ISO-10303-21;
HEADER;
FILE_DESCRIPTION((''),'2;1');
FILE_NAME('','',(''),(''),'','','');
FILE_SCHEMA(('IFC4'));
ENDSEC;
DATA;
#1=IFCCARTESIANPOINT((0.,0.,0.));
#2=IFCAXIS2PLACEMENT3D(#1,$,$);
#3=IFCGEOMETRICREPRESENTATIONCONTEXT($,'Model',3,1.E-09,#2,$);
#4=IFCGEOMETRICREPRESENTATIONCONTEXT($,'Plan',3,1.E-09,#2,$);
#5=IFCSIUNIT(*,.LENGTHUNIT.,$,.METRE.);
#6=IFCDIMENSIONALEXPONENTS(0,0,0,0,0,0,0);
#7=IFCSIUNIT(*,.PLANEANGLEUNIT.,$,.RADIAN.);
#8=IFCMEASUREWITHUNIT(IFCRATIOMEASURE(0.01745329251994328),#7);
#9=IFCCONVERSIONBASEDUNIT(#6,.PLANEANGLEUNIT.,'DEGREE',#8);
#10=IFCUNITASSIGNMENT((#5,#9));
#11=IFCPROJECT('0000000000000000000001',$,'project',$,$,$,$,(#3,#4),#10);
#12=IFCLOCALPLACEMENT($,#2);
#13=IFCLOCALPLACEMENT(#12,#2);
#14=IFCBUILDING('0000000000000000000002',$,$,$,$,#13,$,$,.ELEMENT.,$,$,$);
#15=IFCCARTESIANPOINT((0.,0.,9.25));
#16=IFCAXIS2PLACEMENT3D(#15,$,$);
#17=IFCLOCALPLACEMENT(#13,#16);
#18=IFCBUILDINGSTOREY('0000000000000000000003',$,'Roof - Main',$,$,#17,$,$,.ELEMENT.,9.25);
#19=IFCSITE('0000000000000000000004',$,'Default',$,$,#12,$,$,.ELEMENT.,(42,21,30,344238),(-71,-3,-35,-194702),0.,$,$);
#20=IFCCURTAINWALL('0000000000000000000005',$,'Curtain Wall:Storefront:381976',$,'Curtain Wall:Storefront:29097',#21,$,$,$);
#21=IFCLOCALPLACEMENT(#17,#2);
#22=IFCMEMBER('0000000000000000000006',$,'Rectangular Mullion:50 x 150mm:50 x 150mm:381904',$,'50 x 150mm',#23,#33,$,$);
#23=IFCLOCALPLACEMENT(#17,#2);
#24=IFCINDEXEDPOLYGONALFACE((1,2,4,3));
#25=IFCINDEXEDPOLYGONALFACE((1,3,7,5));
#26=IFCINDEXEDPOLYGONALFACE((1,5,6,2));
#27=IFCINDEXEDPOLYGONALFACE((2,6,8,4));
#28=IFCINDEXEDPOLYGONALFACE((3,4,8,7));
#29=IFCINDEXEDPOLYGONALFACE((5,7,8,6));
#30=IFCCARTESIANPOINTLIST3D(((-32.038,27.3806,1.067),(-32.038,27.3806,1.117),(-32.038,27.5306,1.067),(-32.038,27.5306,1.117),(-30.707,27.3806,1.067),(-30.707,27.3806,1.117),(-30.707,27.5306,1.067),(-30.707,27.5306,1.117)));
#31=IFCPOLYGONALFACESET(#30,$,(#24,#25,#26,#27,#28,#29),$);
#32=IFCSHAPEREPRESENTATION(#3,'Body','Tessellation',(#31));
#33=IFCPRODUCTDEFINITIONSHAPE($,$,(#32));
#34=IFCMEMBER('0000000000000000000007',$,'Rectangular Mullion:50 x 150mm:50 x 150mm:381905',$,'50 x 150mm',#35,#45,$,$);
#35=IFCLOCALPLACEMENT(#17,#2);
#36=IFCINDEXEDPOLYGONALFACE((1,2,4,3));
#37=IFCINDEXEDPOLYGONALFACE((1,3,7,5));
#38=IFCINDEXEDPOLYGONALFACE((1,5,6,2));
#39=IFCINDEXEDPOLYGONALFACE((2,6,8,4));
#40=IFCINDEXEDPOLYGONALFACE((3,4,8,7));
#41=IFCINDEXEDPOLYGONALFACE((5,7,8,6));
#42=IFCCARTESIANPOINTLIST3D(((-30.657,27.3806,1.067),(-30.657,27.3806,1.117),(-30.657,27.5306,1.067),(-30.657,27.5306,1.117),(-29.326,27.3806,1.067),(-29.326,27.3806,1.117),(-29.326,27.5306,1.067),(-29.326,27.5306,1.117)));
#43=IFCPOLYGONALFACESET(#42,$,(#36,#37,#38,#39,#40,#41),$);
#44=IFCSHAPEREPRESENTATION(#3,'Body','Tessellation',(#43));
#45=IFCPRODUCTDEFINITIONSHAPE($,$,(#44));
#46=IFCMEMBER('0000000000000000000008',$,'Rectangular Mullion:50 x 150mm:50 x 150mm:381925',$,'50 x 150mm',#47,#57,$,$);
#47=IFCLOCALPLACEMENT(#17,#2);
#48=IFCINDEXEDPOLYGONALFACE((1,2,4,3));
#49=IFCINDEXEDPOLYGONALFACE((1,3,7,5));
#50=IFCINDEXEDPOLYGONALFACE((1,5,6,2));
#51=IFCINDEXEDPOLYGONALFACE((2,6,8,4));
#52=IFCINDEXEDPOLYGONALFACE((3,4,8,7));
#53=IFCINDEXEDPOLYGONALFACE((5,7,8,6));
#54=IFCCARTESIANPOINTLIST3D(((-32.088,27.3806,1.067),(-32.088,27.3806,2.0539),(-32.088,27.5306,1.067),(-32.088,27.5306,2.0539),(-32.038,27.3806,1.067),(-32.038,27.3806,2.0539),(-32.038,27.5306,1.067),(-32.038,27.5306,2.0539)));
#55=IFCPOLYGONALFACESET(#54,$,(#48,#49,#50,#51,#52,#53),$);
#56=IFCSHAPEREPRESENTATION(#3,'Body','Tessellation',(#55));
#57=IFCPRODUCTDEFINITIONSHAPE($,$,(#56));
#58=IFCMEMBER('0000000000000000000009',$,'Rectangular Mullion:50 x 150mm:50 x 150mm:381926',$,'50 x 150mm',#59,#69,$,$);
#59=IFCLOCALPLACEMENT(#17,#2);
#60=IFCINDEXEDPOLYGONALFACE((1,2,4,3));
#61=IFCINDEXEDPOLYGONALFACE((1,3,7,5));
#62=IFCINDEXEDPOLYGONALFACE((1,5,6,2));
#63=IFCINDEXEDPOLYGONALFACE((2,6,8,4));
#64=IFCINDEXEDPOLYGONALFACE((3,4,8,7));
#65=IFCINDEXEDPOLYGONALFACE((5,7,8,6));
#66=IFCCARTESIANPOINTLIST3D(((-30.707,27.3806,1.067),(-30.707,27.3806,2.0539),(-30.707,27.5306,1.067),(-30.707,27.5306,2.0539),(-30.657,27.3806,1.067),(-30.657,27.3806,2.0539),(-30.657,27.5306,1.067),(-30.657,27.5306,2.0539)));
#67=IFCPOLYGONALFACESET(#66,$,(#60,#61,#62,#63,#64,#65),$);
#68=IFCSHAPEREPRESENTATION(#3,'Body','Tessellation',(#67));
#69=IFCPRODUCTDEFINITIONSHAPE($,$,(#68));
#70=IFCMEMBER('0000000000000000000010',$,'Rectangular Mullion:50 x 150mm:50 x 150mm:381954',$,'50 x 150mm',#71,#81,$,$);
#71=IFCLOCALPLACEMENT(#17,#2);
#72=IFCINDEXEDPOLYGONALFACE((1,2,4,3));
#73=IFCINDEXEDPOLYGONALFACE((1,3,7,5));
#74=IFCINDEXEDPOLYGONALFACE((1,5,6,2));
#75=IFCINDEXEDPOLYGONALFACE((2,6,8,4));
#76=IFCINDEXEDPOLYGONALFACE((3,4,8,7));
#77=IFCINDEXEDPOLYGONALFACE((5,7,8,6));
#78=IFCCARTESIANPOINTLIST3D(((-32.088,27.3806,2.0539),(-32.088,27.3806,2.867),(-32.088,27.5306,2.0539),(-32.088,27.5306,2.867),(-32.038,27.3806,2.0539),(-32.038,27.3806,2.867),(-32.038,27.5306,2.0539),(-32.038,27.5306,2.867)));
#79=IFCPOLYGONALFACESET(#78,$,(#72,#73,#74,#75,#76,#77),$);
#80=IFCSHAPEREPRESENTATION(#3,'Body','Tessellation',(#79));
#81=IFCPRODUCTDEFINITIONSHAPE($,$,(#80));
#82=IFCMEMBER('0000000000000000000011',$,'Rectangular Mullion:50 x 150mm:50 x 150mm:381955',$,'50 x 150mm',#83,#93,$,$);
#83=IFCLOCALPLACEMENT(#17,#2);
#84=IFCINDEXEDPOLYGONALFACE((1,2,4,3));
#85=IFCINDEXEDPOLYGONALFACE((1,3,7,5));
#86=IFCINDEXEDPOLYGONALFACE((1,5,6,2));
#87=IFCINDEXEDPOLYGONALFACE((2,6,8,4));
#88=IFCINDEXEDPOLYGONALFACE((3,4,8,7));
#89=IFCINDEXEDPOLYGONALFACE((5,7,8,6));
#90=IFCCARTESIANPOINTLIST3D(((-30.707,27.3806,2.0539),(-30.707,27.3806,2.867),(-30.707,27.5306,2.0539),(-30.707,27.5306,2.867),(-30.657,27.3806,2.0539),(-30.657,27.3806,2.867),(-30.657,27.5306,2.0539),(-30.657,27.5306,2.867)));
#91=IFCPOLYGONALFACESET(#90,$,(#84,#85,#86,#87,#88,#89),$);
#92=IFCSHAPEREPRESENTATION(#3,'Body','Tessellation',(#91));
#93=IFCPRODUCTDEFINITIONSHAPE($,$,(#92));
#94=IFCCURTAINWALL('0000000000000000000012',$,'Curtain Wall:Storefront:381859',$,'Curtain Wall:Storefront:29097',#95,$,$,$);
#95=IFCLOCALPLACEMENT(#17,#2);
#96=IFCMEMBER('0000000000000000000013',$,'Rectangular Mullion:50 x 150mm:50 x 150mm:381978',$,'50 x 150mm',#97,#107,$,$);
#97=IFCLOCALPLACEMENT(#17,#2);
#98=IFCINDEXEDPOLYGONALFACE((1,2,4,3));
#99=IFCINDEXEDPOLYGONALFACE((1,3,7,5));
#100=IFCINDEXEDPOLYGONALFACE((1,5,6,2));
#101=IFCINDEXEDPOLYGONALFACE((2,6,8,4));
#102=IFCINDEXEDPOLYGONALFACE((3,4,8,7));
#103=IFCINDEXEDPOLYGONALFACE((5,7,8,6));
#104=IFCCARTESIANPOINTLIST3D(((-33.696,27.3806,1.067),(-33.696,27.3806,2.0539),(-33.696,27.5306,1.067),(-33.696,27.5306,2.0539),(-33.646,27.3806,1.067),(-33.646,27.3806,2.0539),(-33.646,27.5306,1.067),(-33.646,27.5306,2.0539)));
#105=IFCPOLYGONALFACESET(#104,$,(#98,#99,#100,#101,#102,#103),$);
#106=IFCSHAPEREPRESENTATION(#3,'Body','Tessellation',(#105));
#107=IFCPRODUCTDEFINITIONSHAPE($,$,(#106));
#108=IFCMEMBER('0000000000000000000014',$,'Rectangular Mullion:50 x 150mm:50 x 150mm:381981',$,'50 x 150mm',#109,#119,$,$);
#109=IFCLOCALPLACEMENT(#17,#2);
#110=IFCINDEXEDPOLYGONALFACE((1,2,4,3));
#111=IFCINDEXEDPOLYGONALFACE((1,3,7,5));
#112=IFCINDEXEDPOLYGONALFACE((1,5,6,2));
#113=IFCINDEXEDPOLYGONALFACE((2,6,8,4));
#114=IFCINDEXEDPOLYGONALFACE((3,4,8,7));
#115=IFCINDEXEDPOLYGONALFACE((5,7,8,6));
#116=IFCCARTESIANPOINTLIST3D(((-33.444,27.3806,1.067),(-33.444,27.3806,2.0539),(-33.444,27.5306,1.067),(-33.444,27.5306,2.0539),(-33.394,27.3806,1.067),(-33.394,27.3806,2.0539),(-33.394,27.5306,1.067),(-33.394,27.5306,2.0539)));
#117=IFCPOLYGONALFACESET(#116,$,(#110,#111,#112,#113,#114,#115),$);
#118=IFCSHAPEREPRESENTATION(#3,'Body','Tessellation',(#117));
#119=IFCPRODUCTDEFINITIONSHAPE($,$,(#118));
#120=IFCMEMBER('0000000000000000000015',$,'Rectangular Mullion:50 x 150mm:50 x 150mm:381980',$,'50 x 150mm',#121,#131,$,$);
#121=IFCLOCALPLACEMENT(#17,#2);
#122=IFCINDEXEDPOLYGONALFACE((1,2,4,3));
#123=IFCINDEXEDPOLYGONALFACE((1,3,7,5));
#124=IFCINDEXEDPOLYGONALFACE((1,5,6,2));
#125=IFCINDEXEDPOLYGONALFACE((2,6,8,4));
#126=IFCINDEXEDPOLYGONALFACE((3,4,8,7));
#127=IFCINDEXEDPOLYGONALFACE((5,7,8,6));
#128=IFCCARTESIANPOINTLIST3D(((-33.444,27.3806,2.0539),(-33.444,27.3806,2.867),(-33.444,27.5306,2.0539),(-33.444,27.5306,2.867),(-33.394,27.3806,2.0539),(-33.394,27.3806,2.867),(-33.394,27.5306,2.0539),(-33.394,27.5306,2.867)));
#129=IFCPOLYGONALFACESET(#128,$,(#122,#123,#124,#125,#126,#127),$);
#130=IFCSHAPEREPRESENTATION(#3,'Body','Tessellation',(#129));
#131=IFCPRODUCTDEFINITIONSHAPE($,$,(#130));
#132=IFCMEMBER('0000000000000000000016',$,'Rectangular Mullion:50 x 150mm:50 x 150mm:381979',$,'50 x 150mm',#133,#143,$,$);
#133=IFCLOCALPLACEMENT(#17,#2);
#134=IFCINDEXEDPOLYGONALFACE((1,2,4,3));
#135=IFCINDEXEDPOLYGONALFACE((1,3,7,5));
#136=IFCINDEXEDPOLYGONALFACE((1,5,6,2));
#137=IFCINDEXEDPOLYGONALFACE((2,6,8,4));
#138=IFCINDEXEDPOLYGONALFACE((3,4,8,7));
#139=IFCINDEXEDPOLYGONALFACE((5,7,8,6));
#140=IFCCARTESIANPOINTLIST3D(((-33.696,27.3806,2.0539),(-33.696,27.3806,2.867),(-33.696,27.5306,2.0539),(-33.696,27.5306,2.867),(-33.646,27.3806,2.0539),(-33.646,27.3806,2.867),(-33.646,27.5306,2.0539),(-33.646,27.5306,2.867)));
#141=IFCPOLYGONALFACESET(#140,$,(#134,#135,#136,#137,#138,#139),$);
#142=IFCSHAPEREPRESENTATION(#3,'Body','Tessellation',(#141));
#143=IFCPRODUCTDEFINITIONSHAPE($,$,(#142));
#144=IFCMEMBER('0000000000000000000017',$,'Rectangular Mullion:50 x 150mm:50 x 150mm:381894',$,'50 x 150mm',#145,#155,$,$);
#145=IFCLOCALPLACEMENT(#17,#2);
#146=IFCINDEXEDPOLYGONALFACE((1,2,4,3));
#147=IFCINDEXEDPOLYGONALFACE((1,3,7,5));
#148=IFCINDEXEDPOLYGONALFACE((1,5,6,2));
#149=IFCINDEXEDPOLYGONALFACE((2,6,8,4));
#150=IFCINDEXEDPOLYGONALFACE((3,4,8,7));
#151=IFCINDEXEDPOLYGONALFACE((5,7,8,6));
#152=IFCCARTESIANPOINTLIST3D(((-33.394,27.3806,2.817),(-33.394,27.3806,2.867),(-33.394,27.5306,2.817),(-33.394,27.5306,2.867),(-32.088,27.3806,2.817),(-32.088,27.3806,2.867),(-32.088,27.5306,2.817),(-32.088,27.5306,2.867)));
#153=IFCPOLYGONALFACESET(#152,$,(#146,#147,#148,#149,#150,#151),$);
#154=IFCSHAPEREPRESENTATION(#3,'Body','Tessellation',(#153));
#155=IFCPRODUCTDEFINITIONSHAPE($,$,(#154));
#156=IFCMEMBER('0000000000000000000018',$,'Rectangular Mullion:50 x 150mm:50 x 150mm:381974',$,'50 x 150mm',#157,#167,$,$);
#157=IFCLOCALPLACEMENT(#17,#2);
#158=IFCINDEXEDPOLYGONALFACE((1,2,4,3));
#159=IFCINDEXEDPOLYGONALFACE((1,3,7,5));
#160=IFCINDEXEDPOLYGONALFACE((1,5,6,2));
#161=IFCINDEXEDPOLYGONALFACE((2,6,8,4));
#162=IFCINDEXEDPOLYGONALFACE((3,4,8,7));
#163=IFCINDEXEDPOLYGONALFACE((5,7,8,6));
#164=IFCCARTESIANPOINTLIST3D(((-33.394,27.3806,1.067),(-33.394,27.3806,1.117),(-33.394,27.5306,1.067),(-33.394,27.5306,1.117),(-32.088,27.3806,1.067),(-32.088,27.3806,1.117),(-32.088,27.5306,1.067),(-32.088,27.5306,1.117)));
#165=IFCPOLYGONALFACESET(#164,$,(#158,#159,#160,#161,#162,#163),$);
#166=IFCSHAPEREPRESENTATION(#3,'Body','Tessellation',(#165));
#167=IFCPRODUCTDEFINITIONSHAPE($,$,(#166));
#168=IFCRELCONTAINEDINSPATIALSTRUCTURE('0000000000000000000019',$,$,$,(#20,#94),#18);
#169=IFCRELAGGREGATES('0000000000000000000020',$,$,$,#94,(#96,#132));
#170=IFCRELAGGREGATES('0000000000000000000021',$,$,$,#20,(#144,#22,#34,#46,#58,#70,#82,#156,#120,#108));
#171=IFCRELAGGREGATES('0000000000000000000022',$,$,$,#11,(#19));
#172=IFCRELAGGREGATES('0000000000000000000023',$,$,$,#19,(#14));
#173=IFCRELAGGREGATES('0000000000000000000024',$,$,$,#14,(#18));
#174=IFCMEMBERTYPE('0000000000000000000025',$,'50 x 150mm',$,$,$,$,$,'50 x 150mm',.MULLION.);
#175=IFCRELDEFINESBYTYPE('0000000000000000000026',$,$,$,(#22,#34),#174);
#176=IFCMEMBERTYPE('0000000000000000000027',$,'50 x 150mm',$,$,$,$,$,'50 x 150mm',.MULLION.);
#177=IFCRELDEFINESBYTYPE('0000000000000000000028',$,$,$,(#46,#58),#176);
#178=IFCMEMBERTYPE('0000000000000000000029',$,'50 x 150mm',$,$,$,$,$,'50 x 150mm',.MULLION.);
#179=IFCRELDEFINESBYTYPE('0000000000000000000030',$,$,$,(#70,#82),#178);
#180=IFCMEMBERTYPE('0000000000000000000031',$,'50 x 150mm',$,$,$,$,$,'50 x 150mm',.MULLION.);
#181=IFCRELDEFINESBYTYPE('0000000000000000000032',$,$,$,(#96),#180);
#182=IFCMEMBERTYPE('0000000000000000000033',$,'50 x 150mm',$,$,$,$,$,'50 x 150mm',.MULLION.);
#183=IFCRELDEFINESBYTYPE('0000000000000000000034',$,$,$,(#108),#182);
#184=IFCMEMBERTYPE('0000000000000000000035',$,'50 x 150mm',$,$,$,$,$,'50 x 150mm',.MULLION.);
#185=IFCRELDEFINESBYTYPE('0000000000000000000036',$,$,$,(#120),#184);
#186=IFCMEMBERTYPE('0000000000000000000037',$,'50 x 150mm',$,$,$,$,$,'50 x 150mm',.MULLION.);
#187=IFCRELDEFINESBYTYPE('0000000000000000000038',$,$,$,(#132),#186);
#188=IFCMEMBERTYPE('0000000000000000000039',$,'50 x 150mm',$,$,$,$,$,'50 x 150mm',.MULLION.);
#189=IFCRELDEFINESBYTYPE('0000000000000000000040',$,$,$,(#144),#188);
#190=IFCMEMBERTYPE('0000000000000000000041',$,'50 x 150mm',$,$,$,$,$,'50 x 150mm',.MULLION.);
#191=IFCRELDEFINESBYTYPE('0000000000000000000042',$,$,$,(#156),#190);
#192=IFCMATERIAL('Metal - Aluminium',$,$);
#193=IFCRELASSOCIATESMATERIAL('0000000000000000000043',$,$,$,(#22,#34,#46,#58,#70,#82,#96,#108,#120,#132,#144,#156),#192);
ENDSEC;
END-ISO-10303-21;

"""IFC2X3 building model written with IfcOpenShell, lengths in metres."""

from ifc_helpers import new_model, entity, si_unit, converted_unit, frame, origin, origin_2d_with_axis, place, context, project, spatial, rectangle, extrude, source, transform, mapped, material, type_object, type_shapes, element, aggregate, save


model = new_model("IFC2X3")

# Units and contexts
model_context = context("Model", 3, precision=1e-09, world=origin())
plan_context = context("Plan", 3, precision=1e-09, world=origin())
ifc_project = project(units=[si_unit("LENGTHUNIT", "METRE"), converted_unit("PLANEANGLEUNIT", "DEGREE", entity("IfcRatioMeasure", 0.01745329251994328), si_unit("PLANEANGLEUNIT", "RADIAN"), dimensions=[0, 0, 0, 0, 0, 0, 0])], contexts=[model_context, plan_context])

# Site, building, storey
site_placement = place(None, origin())
site = spatial("IfcSite", under=ifc_project, at=site_placement, Name="Default", CompositionType="ELEMENT", RefLatitude=(42, 21, 30, 344238), RefLongitude=(-71, -3, -35, -194702), RefElevation=0.0)
building_placement = place(site_placement, origin())
building = spatial("IfcBuilding", under=site, at=building_placement, CompositionType="ELEMENT")
storey_placement = place(building_placement, frame((0.0, 0.0, 9.25)))
storey = spatial("IfcBuildingStorey", under=building, at=storey_placement, Name="Roof - Main", CompositionType="ELEMENT", Elevation=9.25)

# Curtain wall, members
curtain_wall_1_placement = place(storey_placement, origin())
curtain_wall_1 = element("IfcCurtainWall", 1, at=curtain_wall_1_placement, inside=storey, Name="Curtain Wall:Storefront:381976", ObjectType="Curtain Wall:Storefront:29097")
ifc_material_1 = material(Name="Metal - Aluminium")
member_type_1 = type_object("IfcMemberType", Name="50 x 150mm", ElementType="50 x 150mm", PredefinedType="MULLION")
shared_shape_1 = source(origin(), model_context, "Body", "SweptSolid", [
    extrude(rectangle(XDim=0.05, YDim=0.15, at=origin_2d_with_axis()), frame((-0.025, 0.0, -1.331), z_axis=(0.0, 0.0, 1.0), x_axis=(-1.0, 0.0, 0.0)), (0.0, 0.0, 1.0), 1.331),
])
type_shapes(member_type_1, [shared_shape_1])
member_1_placement = place(storey_placement, frame((-32.038, 27.4556, 1.067), z_axis=(-1.0, 0.0, 0.0), x_axis=(0.0, 0.0, -1.0)))
member_1 = element("IfcMember", 2, at=member_1_placement, type_object=member_type_1, material=ifc_material_1, Name="Rectangular Mullion:50 x 150mm:50 x 150mm:381904", ObjectType="50 x 150mm", context=model_context, shape_type="MappedRepresentation", body=[
    mapped(shared_shape_1, transform((0.0, 0.0, 0.0), scale=1.0)),
])
member_2_placement = place(storey_placement, frame((-30.657, 27.4556, 1.067), z_axis=(-1.0, 0.0, 0.0), x_axis=(0.0, 0.0, -1.0)))
member_2 = element("IfcMember", 3, at=member_2_placement, type_object=member_type_1, material=ifc_material_1, Name="Rectangular Mullion:50 x 150mm:50 x 150mm:381905", ObjectType="50 x 150mm", context=model_context, shape_type="MappedRepresentation", body=[
    mapped(shared_shape_1, transform((0.0, 0.0, 0.0), scale=1.0)),
])
member_type_2 = type_object("IfcMemberType", Name="50 x 150mm", ElementType="50 x 150mm", PredefinedType="MULLION")
shared_shape_2 = source(origin(), model_context, "Body", "SweptSolid", [
    extrude(rectangle(XDim=0.05, YDim=0.15, at=origin_2d_with_axis()), frame((0.0, 0.0, -0.9869), z_axis=(0.0, 0.0, 1.0), x_axis=(-1.0, 0.0, 0.0)), (0.0, 0.0, 1.0), 0.9869),
])
type_shapes(member_type_2, [shared_shape_2])
member_3_placement = place(storey_placement, frame((-32.063, 27.4556, 1.067), z_axis=(0.0, 0.0, -1.0), x_axis=(1.0, 0.0, 0.0)))
member_3 = element("IfcMember", 4, at=member_3_placement, type_object=member_type_2, material=ifc_material_1, Name="Rectangular Mullion:50 x 150mm:50 x 150mm:381925", ObjectType="50 x 150mm", context=model_context, shape_type="MappedRepresentation", body=[
    mapped(shared_shape_2, transform((0.0, 0.0, 0.0), scale=1.0)),
])
member_4_placement = place(storey_placement, frame((-30.682, 27.4556, 1.067), z_axis=(0.0, 0.0, -1.0), x_axis=(1.0, 0.0, 0.0)))
member_4 = element("IfcMember", 5, at=member_4_placement, type_object=member_type_2, material=ifc_material_1, Name="Rectangular Mullion:50 x 150mm:50 x 150mm:381926", ObjectType="50 x 150mm", context=model_context, shape_type="MappedRepresentation", body=[
    mapped(shared_shape_2, transform((0.0, 0.0, 0.0), scale=1.0)),
])
member_type_3 = type_object("IfcMemberType", Name="50 x 150mm", ElementType="50 x 150mm", PredefinedType="MULLION")
shared_shape_3 = source(origin(), model_context, "Body", "SweptSolid", [
    extrude(rectangle(XDim=0.05, YDim=0.15, at=origin_2d_with_axis()), frame((0.0, 0.0, -0.8131), z_axis=(0.0, 0.0, 1.0), x_axis=(-1.0, 0.0, 0.0)), (0.0, 0.0, 1.0), 0.8131),
])
type_shapes(member_type_3, [shared_shape_3])
member_5_placement = place(storey_placement, frame((-32.063, 27.4556, 2.0539), z_axis=(0.0, 0.0, -1.0), x_axis=(1.0, 0.0, 0.0)))
member_5 = element("IfcMember", 6, at=member_5_placement, type_object=member_type_3, material=ifc_material_1, Name="Rectangular Mullion:50 x 150mm:50 x 150mm:381954", ObjectType="50 x 150mm", context=model_context, shape_type="MappedRepresentation", body=[
    mapped(shared_shape_3, transform((0.0, 0.0, 0.0), scale=1.0)),
])
member_6_placement = place(storey_placement, frame((-30.682, 27.4556, 2.0539), z_axis=(0.0, 0.0, -1.0), x_axis=(1.0, 0.0, 0.0)))
member_6 = element("IfcMember", 7, at=member_6_placement, type_object=member_type_3, material=ifc_material_1, Name="Rectangular Mullion:50 x 150mm:50 x 150mm:381955", ObjectType="50 x 150mm", context=model_context, shape_type="MappedRepresentation", body=[
    mapped(shared_shape_3, transform((0.0, 0.0, 0.0), scale=1.0)),
])

# Curtain wall, member
curtain_wall_2_placement = place(storey_placement, origin())
curtain_wall_2 = element("IfcCurtainWall", 8, at=curtain_wall_2_placement, inside=storey, Name="Curtain Wall:Storefront:381859", ObjectType="Curtain Wall:Storefront:29097")
member_type_4 = type_object("IfcMemberType", Name="50 x 150mm", ElementType="50 x 150mm", PredefinedType="MULLION")
shared_shape_4 = source(origin(), model_context, "Body", "SweptSolid", [
    extrude(rectangle(XDim=0.05, YDim=0.15, at=origin_2d_with_axis()), frame((-0.025, 0.0, -0.9869), z_axis=(0.0, 0.0, 1.0), x_axis=(-1.0, 0.0, 0.0)), (0.0, 0.0, 1.0), 0.9869),
])
type_shapes(member_type_4, [shared_shape_4])
member_7_placement = place(storey_placement, frame((-33.646, 27.4556, 1.067), z_axis=(0.0, 0.0, -1.0), x_axis=(1.0, 0.0, 0.0)))
member_7 = element("IfcMember", 9, at=member_7_placement, type_object=member_type_4, material=ifc_material_1, Name="Rectangular Mullion:50 x 150mm:50 x 150mm:381978", ObjectType="50 x 150mm", context=model_context, shape_type="MappedRepresentation", body=[
    mapped(shared_shape_4, transform((0.0, 0.0, 0.0), scale=1.0)),
])

# Members
member_type_5 = type_object("IfcMemberType", Name="50 x 150mm", ElementType="50 x 150mm", PredefinedType="MULLION")
shared_shape_5 = source(origin(), model_context, "Body", "SweptSolid", [
    extrude(rectangle(XDim=0.05, YDim=0.15, at=origin_2d_with_axis()), frame((-0.025, 0.0, -0.9869), z_axis=(0.0, 0.0, 1.0), x_axis=(-1.0, 0.0, 0.0)), (0.0, 0.0, 1.0), 0.9869),
])
type_shapes(member_type_5, [shared_shape_5])
member_8_placement = place(storey_placement, frame((-33.444, 27.4556, 2.0539), z_axis=(0.0, 0.0, 1.0), x_axis=(-1.0, 0.0, 0.0)))
member_8 = element("IfcMember", 10, at=member_8_placement, type_object=member_type_5, material=ifc_material_1, Name="Rectangular Mullion:50 x 150mm:50 x 150mm:381981", ObjectType="50 x 150mm", context=model_context, shape_type="MappedRepresentation", body=[
    mapped(shared_shape_5, transform((0.0, 0.0, 0.0), scale=1.0)),
])
member_type_6 = type_object("IfcMemberType", Name="50 x 150mm", ElementType="50 x 150mm", PredefinedType="MULLION")
shared_shape_6 = source(origin(), model_context, "Body", "SweptSolid", [
    extrude(rectangle(XDim=0.05, YDim=0.15, at=origin_2d_with_axis()), frame((-0.025, 0.0, -0.8131), z_axis=(0.0, 0.0, 1.0), x_axis=(-1.0, 0.0, 0.0)), (0.0, 0.0, 1.0), 0.8131),
])
type_shapes(member_type_6, [shared_shape_6])
member_9_placement = place(storey_placement, frame((-33.444, 27.4556, 2.867), z_axis=(0.0, 0.0, 1.0), x_axis=(-1.0, 0.0, 0.0)))
member_9 = element("IfcMember", 11, at=member_9_placement, type_object=member_type_6, material=ifc_material_1, Name="Rectangular Mullion:50 x 150mm:50 x 150mm:381980", ObjectType="50 x 150mm", context=model_context, shape_type="MappedRepresentation", body=[
    mapped(shared_shape_6, transform((0.0, 0.0, 0.0), scale=1.0)),
])
member_type_7 = type_object("IfcMemberType", Name="50 x 150mm", ElementType="50 x 150mm", PredefinedType="MULLION")
shared_shape_7 = source(origin(), model_context, "Body", "SweptSolid", [
    extrude(rectangle(XDim=0.05, YDim=0.15, at=origin_2d_with_axis()), frame((-0.025, 0.0, -0.8131), z_axis=(0.0, 0.0, 1.0), x_axis=(-1.0, 0.0, 0.0)), (0.0, 0.0, 1.0), 0.8131),
])
type_shapes(member_type_7, [shared_shape_7])
member_10_placement = place(storey_placement, frame((-33.646, 27.4556, 2.0539), z_axis=(0.0, 0.0, -1.0), x_axis=(1.0, 0.0, 0.0)))
member_10 = element("IfcMember", 12, at=member_10_placement, type_object=member_type_7, material=ifc_material_1, Name="Rectangular Mullion:50 x 150mm:50 x 150mm:381979", ObjectType="50 x 150mm", context=model_context, shape_type="MappedRepresentation", body=[
    mapped(shared_shape_7, transform((0.0, 0.0, 0.0), scale=1.0)),
])
aggregate(curtain_wall_2, [member_7, member_10])
member_type_8 = type_object("IfcMemberType", Name="50 x 150mm", ElementType="50 x 150mm", PredefinedType="MULLION")
shared_shape_8 = source(origin(), model_context, "Body", "SweptSolid", [
    extrude(rectangle(XDim=0.05, YDim=0.15, at=origin_2d_with_axis()), frame((-0.025, 0.0, -1.306), z_axis=(0.0, 0.0, 1.0), x_axis=(-1.0, 0.0, 0.0)), (0.0, 0.0, 1.0), 1.306),
])
type_shapes(member_type_8, [shared_shape_8])
member_11_placement = place(storey_placement, frame((-32.088, 27.4556, 2.867), z_axis=(1.0, 0.0, 0.0), x_axis=(0.0, 0.0, 1.0)))
member_11 = element("IfcMember", 13, at=member_11_placement, type_object=member_type_8, material=ifc_material_1, Name="Rectangular Mullion:50 x 150mm:50 x 150mm:381894", ObjectType="50 x 150mm", context=model_context, shape_type="MappedRepresentation", body=[
    mapped(shared_shape_8, transform((0.0, 0.0, 0.0), scale=1.0)),
])
member_type_9 = type_object("IfcMemberType", Name="50 x 150mm", ElementType="50 x 150mm", PredefinedType="MULLION")
shared_shape_9 = source(origin(), model_context, "Body", "SweptSolid", [
    extrude(rectangle(XDim=0.05, YDim=0.15, at=origin_2d_with_axis()), frame((-0.025, 0.0, -1.306), z_axis=(0.0, 0.0, 1.0), x_axis=(-1.0, 0.0, 0.0)), (0.0, 0.0, 1.0), 1.306),
])
type_shapes(member_type_9, [shared_shape_9])
member_12_placement = place(storey_placement, frame((-33.394, 27.4556, 1.067), z_axis=(-1.0, 0.0, 0.0), x_axis=(0.0, 0.0, -1.0)))
member_12 = element("IfcMember", 14, at=member_12_placement, type_object=member_type_9, material=ifc_material_1, Name="Rectangular Mullion:50 x 150mm:50 x 150mm:381974", ObjectType="50 x 150mm", context=model_context, shape_type="MappedRepresentation", body=[
    mapped(shared_shape_9, transform((0.0, 0.0, 0.0), scale=1.0)),
])

aggregate(curtain_wall_1, [member_11, member_1, member_2, member_3, member_4, member_5, member_6, member_12, member_9, member_8])

save(model, "model.ifc")
